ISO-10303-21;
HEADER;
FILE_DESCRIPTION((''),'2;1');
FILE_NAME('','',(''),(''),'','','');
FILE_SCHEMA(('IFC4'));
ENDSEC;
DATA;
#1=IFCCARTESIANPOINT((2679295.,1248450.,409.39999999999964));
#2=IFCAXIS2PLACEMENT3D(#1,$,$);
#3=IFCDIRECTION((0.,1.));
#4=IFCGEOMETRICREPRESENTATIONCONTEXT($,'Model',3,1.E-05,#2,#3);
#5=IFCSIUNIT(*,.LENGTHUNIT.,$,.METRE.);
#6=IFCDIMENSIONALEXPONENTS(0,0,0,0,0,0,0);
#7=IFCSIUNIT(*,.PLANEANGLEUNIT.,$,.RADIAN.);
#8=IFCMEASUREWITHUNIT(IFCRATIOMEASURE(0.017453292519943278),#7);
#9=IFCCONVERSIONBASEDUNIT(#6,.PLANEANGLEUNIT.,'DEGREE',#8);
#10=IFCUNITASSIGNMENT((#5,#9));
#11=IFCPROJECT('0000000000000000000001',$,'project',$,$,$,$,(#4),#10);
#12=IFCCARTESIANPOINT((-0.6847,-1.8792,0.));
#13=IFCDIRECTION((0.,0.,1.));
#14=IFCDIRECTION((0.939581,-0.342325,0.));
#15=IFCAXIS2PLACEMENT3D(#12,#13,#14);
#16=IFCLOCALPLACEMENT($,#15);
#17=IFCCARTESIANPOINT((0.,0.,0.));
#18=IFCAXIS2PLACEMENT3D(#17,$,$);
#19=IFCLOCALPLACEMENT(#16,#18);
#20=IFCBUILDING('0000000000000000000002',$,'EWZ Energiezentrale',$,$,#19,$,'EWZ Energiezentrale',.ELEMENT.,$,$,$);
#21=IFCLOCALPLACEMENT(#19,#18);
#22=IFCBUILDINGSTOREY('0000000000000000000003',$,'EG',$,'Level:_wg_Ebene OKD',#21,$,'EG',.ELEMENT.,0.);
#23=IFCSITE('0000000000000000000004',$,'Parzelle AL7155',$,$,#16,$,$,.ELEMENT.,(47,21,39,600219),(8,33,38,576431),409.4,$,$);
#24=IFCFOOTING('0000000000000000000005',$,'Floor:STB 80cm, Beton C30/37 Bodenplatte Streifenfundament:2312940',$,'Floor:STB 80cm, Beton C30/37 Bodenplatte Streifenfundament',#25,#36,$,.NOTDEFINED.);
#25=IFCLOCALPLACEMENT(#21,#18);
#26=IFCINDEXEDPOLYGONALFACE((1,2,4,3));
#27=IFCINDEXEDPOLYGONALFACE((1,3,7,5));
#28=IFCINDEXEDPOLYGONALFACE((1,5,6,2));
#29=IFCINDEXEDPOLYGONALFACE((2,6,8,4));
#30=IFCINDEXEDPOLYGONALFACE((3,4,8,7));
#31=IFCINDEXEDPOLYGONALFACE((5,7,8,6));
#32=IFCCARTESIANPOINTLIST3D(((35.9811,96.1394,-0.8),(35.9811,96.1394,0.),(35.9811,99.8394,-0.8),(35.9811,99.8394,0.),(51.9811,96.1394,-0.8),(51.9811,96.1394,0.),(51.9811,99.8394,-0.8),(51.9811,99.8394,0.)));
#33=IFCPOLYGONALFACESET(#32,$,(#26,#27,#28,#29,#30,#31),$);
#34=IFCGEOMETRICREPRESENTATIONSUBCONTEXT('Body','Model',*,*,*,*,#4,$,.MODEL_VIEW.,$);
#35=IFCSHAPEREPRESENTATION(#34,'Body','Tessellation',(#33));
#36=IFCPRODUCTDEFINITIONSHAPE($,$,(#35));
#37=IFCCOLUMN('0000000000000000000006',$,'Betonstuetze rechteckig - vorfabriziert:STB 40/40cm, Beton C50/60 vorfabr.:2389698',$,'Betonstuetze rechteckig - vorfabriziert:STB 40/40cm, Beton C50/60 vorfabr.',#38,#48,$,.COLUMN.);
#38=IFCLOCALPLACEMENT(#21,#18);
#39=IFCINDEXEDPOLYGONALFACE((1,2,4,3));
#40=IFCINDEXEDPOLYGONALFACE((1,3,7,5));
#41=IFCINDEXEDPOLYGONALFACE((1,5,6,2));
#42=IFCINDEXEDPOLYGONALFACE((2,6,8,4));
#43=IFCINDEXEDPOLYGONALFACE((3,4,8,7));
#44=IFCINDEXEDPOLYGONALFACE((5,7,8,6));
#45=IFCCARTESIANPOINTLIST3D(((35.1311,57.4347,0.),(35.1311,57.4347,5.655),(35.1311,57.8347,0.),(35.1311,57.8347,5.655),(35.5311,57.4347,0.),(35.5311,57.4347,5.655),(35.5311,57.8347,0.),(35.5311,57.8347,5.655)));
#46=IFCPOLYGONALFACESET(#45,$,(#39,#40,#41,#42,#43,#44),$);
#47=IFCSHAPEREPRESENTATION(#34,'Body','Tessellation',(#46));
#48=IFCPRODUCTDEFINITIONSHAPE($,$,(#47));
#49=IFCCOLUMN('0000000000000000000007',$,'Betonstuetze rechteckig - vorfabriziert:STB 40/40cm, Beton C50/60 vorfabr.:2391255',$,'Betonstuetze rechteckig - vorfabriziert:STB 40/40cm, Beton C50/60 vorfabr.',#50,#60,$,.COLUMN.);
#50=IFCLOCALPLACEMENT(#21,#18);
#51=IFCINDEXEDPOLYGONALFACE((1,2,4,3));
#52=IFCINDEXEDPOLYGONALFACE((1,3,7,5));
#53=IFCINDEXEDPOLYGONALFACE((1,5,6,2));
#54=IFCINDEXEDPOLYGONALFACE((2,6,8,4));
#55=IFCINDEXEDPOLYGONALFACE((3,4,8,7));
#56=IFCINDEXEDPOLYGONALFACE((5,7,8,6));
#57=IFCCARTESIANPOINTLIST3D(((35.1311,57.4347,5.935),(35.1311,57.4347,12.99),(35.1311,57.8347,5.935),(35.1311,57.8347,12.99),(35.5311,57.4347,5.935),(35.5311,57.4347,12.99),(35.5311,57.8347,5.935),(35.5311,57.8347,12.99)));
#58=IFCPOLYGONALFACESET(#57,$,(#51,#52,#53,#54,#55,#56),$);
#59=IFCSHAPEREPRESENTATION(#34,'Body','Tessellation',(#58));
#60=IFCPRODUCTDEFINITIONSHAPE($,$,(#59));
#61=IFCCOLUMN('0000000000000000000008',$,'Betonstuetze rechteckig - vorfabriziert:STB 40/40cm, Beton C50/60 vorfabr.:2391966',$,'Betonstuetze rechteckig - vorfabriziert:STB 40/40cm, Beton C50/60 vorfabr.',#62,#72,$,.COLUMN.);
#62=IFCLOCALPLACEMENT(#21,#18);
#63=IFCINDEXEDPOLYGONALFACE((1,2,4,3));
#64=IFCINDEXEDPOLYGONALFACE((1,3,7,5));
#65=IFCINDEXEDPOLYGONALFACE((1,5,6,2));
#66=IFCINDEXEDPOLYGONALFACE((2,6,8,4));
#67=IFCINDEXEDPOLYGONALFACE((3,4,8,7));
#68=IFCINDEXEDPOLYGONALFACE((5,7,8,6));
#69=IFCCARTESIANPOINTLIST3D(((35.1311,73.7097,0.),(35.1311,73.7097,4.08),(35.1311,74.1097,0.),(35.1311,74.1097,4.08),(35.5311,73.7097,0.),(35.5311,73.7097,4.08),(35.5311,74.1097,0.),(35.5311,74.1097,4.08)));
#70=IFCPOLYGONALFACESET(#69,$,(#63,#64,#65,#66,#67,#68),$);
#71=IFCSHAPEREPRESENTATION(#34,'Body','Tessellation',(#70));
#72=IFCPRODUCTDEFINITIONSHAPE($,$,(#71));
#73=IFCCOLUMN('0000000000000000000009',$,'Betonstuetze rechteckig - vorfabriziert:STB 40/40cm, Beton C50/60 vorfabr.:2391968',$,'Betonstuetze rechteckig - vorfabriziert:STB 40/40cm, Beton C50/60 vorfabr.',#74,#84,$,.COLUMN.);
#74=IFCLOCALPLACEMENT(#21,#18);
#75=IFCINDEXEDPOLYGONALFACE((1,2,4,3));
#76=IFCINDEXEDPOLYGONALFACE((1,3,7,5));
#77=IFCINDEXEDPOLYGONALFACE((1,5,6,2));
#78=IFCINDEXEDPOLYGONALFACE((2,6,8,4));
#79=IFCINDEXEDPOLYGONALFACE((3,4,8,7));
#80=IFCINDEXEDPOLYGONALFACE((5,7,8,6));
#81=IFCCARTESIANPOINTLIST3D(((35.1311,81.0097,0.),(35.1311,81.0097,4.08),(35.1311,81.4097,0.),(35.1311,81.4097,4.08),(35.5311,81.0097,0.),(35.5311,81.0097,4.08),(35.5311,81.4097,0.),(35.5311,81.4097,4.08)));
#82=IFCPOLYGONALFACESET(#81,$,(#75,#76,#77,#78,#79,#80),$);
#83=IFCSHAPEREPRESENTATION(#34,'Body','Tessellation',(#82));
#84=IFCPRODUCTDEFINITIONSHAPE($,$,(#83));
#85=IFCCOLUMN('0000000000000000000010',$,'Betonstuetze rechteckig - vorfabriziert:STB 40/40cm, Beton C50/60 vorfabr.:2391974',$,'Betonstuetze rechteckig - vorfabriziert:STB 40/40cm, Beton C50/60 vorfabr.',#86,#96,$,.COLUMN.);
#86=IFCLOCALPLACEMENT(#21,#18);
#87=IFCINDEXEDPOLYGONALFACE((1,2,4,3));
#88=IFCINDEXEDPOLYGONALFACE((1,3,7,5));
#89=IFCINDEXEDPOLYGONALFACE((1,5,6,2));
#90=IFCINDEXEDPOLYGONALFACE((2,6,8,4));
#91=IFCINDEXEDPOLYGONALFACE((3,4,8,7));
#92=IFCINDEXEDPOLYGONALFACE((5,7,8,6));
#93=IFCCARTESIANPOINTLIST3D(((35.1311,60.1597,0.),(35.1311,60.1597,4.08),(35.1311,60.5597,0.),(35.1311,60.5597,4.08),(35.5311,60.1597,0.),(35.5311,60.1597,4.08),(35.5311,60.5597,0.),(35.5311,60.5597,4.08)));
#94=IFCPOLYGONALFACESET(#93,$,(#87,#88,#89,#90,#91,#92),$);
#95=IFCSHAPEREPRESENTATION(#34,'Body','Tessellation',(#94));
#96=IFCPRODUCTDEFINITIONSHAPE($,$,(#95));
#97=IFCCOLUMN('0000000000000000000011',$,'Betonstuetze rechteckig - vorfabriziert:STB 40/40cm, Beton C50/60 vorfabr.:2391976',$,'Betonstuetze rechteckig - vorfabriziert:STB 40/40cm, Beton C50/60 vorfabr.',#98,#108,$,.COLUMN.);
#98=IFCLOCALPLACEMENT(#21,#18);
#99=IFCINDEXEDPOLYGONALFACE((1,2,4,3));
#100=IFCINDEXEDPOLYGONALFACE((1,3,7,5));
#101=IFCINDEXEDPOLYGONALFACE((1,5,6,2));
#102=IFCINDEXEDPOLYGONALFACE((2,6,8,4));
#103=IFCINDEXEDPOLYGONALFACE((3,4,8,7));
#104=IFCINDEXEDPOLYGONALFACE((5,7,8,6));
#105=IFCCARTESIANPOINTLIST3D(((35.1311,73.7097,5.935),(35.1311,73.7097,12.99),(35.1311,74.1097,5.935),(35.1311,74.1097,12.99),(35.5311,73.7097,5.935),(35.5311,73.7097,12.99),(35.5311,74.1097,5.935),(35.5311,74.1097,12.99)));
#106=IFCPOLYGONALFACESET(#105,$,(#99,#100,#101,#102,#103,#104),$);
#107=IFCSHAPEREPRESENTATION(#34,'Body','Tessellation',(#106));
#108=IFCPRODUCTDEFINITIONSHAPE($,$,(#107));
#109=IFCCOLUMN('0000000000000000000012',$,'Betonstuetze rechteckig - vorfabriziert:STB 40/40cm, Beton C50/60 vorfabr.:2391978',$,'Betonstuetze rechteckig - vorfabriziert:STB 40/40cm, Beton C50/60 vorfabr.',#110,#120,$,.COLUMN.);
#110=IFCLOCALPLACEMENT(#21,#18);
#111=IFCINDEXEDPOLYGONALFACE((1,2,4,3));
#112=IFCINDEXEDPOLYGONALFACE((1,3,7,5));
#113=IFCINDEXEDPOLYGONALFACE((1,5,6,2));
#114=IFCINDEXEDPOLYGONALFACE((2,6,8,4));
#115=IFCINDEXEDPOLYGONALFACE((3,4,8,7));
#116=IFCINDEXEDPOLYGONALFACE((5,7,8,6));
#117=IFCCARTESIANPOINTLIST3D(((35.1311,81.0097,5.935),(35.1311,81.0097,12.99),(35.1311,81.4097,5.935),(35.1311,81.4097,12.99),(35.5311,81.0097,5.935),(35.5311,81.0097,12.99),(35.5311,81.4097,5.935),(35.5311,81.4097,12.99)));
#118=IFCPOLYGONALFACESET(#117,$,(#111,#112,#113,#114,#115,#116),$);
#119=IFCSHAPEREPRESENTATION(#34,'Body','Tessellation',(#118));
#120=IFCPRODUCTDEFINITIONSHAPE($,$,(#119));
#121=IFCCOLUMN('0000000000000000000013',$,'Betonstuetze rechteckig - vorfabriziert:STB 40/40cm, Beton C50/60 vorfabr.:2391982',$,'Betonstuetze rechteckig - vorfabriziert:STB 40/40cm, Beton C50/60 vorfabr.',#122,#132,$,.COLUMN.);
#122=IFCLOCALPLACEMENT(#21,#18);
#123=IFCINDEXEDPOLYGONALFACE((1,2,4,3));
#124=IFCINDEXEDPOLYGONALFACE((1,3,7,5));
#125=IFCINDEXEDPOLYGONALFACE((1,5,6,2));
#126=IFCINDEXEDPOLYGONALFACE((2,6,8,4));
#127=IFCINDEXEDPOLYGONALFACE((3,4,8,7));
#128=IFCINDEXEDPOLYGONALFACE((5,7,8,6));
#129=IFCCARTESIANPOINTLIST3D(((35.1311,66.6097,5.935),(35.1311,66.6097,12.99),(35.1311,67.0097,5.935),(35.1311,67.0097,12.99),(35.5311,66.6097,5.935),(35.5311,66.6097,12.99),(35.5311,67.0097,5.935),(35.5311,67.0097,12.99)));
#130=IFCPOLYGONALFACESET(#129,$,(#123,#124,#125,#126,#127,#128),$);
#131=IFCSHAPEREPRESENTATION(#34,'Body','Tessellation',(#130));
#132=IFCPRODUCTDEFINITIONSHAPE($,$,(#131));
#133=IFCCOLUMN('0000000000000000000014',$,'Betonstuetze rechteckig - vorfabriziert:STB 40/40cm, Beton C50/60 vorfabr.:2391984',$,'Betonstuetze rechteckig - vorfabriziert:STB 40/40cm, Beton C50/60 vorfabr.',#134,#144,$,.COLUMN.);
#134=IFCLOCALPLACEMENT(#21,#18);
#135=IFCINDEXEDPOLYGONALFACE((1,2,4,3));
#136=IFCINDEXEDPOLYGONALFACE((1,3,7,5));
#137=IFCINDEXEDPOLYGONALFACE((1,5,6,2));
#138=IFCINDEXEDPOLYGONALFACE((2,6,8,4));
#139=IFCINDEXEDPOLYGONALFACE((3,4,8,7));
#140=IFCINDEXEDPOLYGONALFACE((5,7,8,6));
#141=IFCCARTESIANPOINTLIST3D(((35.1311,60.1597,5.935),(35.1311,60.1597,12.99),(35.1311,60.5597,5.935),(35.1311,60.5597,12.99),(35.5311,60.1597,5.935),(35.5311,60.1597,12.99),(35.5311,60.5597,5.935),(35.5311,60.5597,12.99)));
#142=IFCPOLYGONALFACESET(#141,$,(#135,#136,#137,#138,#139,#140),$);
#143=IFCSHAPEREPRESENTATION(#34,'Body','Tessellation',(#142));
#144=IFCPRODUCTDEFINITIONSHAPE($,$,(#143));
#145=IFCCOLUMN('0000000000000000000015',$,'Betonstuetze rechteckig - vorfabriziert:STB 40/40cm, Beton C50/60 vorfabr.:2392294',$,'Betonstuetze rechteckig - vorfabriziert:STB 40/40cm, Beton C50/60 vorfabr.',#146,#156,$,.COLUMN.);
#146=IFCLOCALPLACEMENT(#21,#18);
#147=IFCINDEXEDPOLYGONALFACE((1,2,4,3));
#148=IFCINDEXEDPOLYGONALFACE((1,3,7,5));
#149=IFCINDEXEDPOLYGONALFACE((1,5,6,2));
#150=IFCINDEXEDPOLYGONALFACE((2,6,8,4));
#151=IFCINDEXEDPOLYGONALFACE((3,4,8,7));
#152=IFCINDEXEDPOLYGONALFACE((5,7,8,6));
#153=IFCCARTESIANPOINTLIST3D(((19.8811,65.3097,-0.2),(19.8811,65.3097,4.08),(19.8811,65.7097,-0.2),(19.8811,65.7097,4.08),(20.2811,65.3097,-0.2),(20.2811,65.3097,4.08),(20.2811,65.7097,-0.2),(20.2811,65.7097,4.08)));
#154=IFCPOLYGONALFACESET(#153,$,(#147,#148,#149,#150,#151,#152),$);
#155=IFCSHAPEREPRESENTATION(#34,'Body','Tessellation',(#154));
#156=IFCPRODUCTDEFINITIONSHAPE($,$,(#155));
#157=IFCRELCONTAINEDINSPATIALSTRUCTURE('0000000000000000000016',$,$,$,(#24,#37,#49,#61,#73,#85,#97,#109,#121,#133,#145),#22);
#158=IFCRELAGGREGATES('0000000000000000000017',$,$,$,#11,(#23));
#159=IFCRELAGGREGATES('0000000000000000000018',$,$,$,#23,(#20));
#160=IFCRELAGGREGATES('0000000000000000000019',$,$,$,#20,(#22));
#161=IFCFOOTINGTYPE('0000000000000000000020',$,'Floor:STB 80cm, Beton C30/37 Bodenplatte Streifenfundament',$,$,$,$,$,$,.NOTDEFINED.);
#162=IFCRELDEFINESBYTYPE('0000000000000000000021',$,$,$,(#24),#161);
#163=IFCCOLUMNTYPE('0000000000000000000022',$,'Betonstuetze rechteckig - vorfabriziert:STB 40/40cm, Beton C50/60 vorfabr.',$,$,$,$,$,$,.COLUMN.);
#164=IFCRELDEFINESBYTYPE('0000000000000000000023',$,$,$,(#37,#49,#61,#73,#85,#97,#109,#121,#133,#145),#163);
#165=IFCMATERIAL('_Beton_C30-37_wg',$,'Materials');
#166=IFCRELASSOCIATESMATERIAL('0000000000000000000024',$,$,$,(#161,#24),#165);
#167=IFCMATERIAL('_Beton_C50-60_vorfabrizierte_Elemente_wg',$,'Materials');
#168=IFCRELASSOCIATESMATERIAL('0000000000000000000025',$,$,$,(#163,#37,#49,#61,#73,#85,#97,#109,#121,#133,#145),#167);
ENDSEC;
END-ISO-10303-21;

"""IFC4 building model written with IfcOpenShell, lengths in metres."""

from ifc_helpers import new_model, entity, si_unit, converted_unit, direction, frame, origin, place, context, subcontext, project, spatial, indexed_curve, outline, extrude, source, transform, mapped, material, type_object, type_shapes, element, save


model = new_model("IFC4")

# Units and contexts
model_context = context("Model", 3, precision=1e-05, world=frame((2679295.0, 1248450.0, 409.39999999999964)), true_north=direction((0.0, 1.0)))
body_context = subcontext(model_context, "Body", "Model", "MODEL_VIEW")
ifc_project = project(units=[si_unit("LENGTHUNIT", "METRE"), converted_unit("PLANEANGLEUNIT", "DEGREE", entity("IfcRatioMeasure", 0.017453292519943278), si_unit("PLANEANGLEUNIT", "RADIAN"), dimensions=[0, 0, 0, 0, 0, 0, 0])], contexts=[model_context])

# Site, building, storey
site_placement = place(None, frame((-0.6847, -1.8792, 0.0), z_axis=(0.0, 0.0, 1.0), x_axis=(0.939581, -0.342325, 0.0)))
site = spatial("IfcSite", under=ifc_project, at=site_placement, Name="Parzelle AL7155", CompositionType="ELEMENT", RefLatitude=(47, 21, 39, 600219), RefLongitude=(8, 33, 38, 576431), RefElevation=409.4)
building_placement = place(site_placement, origin())
building = spatial("IfcBuilding", under=site, at=building_placement, Name="EWZ Energiezentrale", LongName="EWZ Energiezentrale", CompositionType="ELEMENT")
storey_placement = place(building_placement, origin())
storey = spatial("IfcBuildingStorey", under=building, at=storey_placement, Name="EG", ObjectType="Level:_wg_Ebene OKD", LongName="EG", CompositionType="ELEMENT", Elevation=0.0)

# Footing
ifc_material_1 = material(Name="_Beton_C30-37_wg", Category="Materials")
footing_type = type_object("IfcFootingType", Name="Floor:STB 80cm, Beton C30/37 Bodenplatte Streifenfundament", PredefinedType="NOTDEFINED", material=ifc_material_1)
footing_placement = place(storey_placement, origin())
element("IfcFooting", 1, at=footing_placement, inside=storey, type_object=footing_type, material=ifc_material_1, Name="Floor:STB 80cm, Beton C30/37 Bodenplatte Streifenfundament:2312940", ObjectType="Floor:STB 80cm, Beton C30/37 Bodenplatte Streifenfundament", PredefinedType="NOTDEFINED", context=body_context, shape_type="SweptSolid", body=[
    extrude(outline(indexed_curve([(-1.85, -8.0), (1.85, -8.0), (1.85, 8.0), (-1.85, 8.0), (-1.85, -8.0)], self_intersect=False)), frame((43.9811, 97.9894, 0.0), z_axis=(0.0, 0.0, -1.0), x_axis=(0.0, 1.0, 0.0)), (0.0, 0.0, 1.0), 0.8),
])

# Columns
ifc_material_2 = material(Name="_Beton_C50-60_vorfabrizierte_Elemente_wg", Category="Materials")
column_type = type_object("IfcColumnType", Name="Betonstuetze rechteckig - vorfabriziert:STB 40/40cm, Beton C50/60 vorfabr.", PredefinedType="COLUMN", material=ifc_material_2)
shared_shape_1 = source(origin(), body_context, "Body", "SweptSolid", [
    extrude(outline(indexed_curve([(-0.2, -0.2), (0.2, -0.2), (0.2, 0.2), (-0.2, 0.2), (-0.2, -0.2)], self_intersect=False)), frame((35.3311, 57.6347, 0.0), z_axis=(0.0, 0.0, 1.0), x_axis=(0.0, -1.0, 0.0)), (0.0, 0.0, 1.0), 5.655),
])
type_shapes(column_type, [shared_shape_1])
column_1_placement = place(storey_placement, origin())
element("IfcColumn", 2, at=column_1_placement, inside=storey, type_object=column_type, material=ifc_material_2, Name="Betonstuetze rechteckig - vorfabriziert:STB 40/40cm, Beton C50/60 vorfabr.:2389698", ObjectType="Betonstuetze rechteckig - vorfabriziert:STB 40/40cm, Beton C50/60 vorfabr.", PredefinedType="COLUMN", context=body_context, shape_type="MappedRepresentation", body=[
    mapped(shared_shape_1, transform((0.0, 0.0, 0.0), scale=1.0)),
])
shared_shape_2 = source(origin(), body_context, "Body", "SweptSolid", [
    extrude(outline(indexed_curve([(-0.2, -0.2), (0.2, -0.2), (0.2, 0.2), (-0.2, 0.2), (-0.2, -0.2)], self_intersect=False)), frame((35.3311, 57.6347, 5.935), z_axis=(0.0, 0.0, 1.0), x_axis=(0.0, -1.0, 0.0)), (0.0, 0.0, 1.0), 7.055),
])
column_2_placement = place(storey_placement, frame((0.0, 0.0, 0.0), z_axis=(0.0, 0.0, 1.0), x_axis=(1.0, 0.0, 0.0)))
element("IfcColumn", 3, at=column_2_placement, inside=storey, type_object=column_type, material=ifc_material_2, Name="Betonstuetze rechteckig - vorfabriziert:STB 40/40cm, Beton C50/60 vorfabr.:2391255", ObjectType="Betonstuetze rechteckig - vorfabriziert:STB 40/40cm, Beton C50/60 vorfabr.", PredefinedType="COLUMN", context=body_context, shape_type="MappedRepresentation", body=[
    mapped(shared_shape_2, transform((0.0, 0.0, 0.0), scale=1.0)),
])
shared_shape_3 = source(origin(), body_context, "Body", "SweptSolid", [
    extrude(outline(indexed_curve([(-0.2, -0.2), (0.2, -0.2), (0.2, 0.2), (-0.2, 0.2), (-0.2, -0.2)], self_intersect=False)), frame((35.3311, 73.9097, 0.0), z_axis=(0.0, 0.0, 1.0), x_axis=(0.0, -1.0, 0.0)), (0.0, 0.0, 1.0), 4.08),
])
column_3_placement = place(storey_placement, origin())
element("IfcColumn", 4, at=column_3_placement, inside=storey, type_object=column_type, material=ifc_material_2, Name="Betonstuetze rechteckig - vorfabriziert:STB 40/40cm, Beton C50/60 vorfabr.:2391966", ObjectType="Betonstuetze rechteckig - vorfabriziert:STB 40/40cm, Beton C50/60 vorfabr.", PredefinedType="COLUMN", context=body_context, shape_type="MappedRepresentation", body=[
    mapped(shared_shape_3, transform((0.0, 0.0, 0.0), scale=1.0)),
])
shared_shape_4 = source(origin(), body_context, "Body", "SweptSolid", [
    extrude(outline(indexed_curve([(-0.2, -0.2), (0.2, -0.2), (0.2, 0.2), (-0.2, 0.2), (-0.2, -0.2)], self_intersect=False)), frame((35.3311, 81.2097, 0.0), z_axis=(0.0, 0.0, 1.0), x_axis=(0.0, -1.0, 0.0)), (0.0, 0.0, 1.0), 4.08),
])
column_4_placement = place(storey_placement, origin())
element("IfcColumn", 5, at=column_4_placement, inside=storey, type_object=column_type, material=ifc_material_2, Name="Betonstuetze rechteckig - vorfabriziert:STB 40/40cm, Beton C50/60 vorfabr.:2391968", ObjectType="Betonstuetze rechteckig - vorfabriziert:STB 40/40cm, Beton C50/60 vorfabr.", PredefinedType="COLUMN", context=body_context, shape_type="MappedRepresentation", body=[
    mapped(shared_shape_4, transform((0.0, 0.0, 0.0), scale=1.0)),
])
shared_shape_5 = source(origin(), body_context, "Body", "SweptSolid", [
    extrude(outline(indexed_curve([(-0.2, -0.2), (0.2, -0.2), (0.2, 0.2), (-0.2, 0.2), (-0.2, -0.2)], self_intersect=False)), frame((35.3311, 60.3597, 0.0), z_axis=(0.0, 0.0, 1.0), x_axis=(-1.0, 0.0, 0.0)), (0.0, 0.0, 1.0), 4.08),
])
column_5_placement = place(storey_placement, origin())
element("IfcColumn", 6, at=column_5_placement, inside=storey, type_object=column_type, material=ifc_material_2, Name="Betonstuetze rechteckig - vorfabriziert:STB 40/40cm, Beton C50/60 vorfabr.:2391974", ObjectType="Betonstuetze rechteckig - vorfabriziert:STB 40/40cm, Beton C50/60 vorfabr.", PredefinedType="COLUMN", context=body_context, shape_type="MappedRepresentation", body=[
    mapped(shared_shape_5, transform((0.0, 0.0, 0.0), scale=1.0)),
])
shared_shape_6 = source(origin(), body_context, "Body", "SweptSolid", [
    extrude(outline(indexed_curve([(-0.2, -0.2), (0.2, -0.2), (0.2, 0.2), (-0.2, 0.2), (-0.2, -0.2)], self_intersect=False)), frame((35.3311, 73.9097, 5.935), z_axis=(0.0, 0.0, 1.0), x_axis=(0.0, -1.0, 0.0)), (0.0, 0.0, 1.0), 7.055),
])
column_6_placement = place(storey_placement, frame((0.0, 0.0, 0.0), z_axis=(0.0, 0.0, 1.0), x_axis=(1.0, 0.0, 0.0)))
element("IfcColumn", 7, at=column_6_placement, inside=storey, type_object=column_type, material=ifc_material_2, Name="Betonstuetze rechteckig - vorfabriziert:STB 40/40cm, Beton C50/60 vorfabr.:2391976", ObjectType="Betonstuetze rechteckig - vorfabriziert:STB 40/40cm, Beton C50/60 vorfabr.", PredefinedType="COLUMN", context=body_context, shape_type="MappedRepresentation", body=[
    mapped(shared_shape_6, transform((0.0, 0.0, 0.0), scale=1.0)),
])
shared_shape_7 = source(origin(), body_context, "Body", "SweptSolid", [
    extrude(outline(indexed_curve([(-0.2, -0.2), (0.2, -0.2), (0.2, 0.2), (-0.2, 0.2), (-0.2, -0.2)], self_intersect=False)), frame((35.3311, 81.2097, 5.935), z_axis=(0.0, 0.0, 1.0), x_axis=(0.0, -1.0, 0.0)), (0.0, 0.0, 1.0), 7.055),
])
column_7_placement = place(storey_placement, frame((0.0, 0.0, 0.0), z_axis=(0.0, 0.0, 1.0), x_axis=(1.0, 0.0, 0.0)))
element("IfcColumn", 8, at=column_7_placement, inside=storey, type_object=column_type, material=ifc_material_2, Name="Betonstuetze rechteckig - vorfabriziert:STB 40/40cm, Beton C50/60 vorfabr.:2391978", ObjectType="Betonstuetze rechteckig - vorfabriziert:STB 40/40cm, Beton C50/60 vorfabr.", PredefinedType="COLUMN", context=body_context, shape_type="MappedRepresentation", body=[
    mapped(shared_shape_7, transform((0.0, 0.0, 0.0), scale=1.0)),
])
shared_shape_8 = source(origin(), body_context, "Body", "SweptSolid", [
    extrude(outline(indexed_curve([(-0.2, -0.2), (0.2, -0.2), (0.2, 0.2), (-0.2, 0.2), (-0.2, -0.2)], self_intersect=False)), frame((35.3311, 66.8097, 5.935), z_axis=(0.0, 0.0, 1.0), x_axis=(0.0, -1.0, 0.0)), (0.0, 0.0, 1.0), 7.055),
])
column_8_placement = place(storey_placement, frame((0.0, 0.0, 0.0), z_axis=(0.0, 0.0, 1.0), x_axis=(1.0, 0.0, 0.0)))
element("IfcColumn", 9, at=column_8_placement, inside=storey, type_object=column_type, material=ifc_material_2, Name="Betonstuetze rechteckig - vorfabriziert:STB 40/40cm, Beton C50/60 vorfabr.:2391982", ObjectType="Betonstuetze rechteckig - vorfabriziert:STB 40/40cm, Beton C50/60 vorfabr.", PredefinedType="COLUMN", context=body_context, shape_type="MappedRepresentation", body=[
    mapped(shared_shape_8, transform((0.0, 0.0, 0.0), scale=1.0)),
])
shared_shape_9 = source(origin(), body_context, "Body", "SweptSolid", [
    extrude(outline(indexed_curve([(-0.2, -0.2), (0.2, -0.2), (0.2, 0.2), (-0.2, 0.2), (-0.2, -0.2)], self_intersect=False)), frame((35.3311, 60.3597, 5.935), z_axis=(0.0, 0.0, 1.0), x_axis=(-1.0, 0.0, 0.0)), (0.0, 0.0, 1.0), 7.055),
])
column_9_placement = place(storey_placement, frame((0.0, 0.0, 0.0), z_axis=(0.0, 0.0, 1.0), x_axis=(1.0, 0.0, 0.0)))
element("IfcColumn", 10, at=column_9_placement, inside=storey, type_object=column_type, material=ifc_material_2, Name="Betonstuetze rechteckig - vorfabriziert:STB 40/40cm, Beton C50/60 vorfabr.:2391984", ObjectType="Betonstuetze rechteckig - vorfabriziert:STB 40/40cm, Beton C50/60 vorfabr.", PredefinedType="COLUMN", context=body_context, shape_type="MappedRepresentation", body=[
    mapped(shared_shape_9, transform((0.0, 0.0, 0.0), scale=1.0)),
])
shared_shape_10 = source(origin(), body_context, "Body", "SweptSolid", [
    extrude(outline(indexed_curve([(-0.2, -0.2), (0.2, -0.2), (0.2, 0.2), (-0.2, 0.2), (-0.2, -0.2)], self_intersect=False)), frame((20.0811, 65.5097, -0.2), z_axis=(0.0, 0.0, 1.0), x_axis=(-1.0, 0.0, 0.0)), (0.0, 0.0, 1.0), 4.28),
])
column_10_placement = place(storey_placement, origin())
element("IfcColumn", 11, at=column_10_placement, inside=storey, type_object=column_type, material=ifc_material_2, Name="Betonstuetze rechteckig - vorfabriziert:STB 40/40cm, Beton C50/60 vorfabr.:2392294", ObjectType="Betonstuetze rechteckig - vorfabriziert:STB 40/40cm, Beton C50/60 vorfabr.", PredefinedType="COLUMN", context=body_context, shape_type="MappedRepresentation", body=[
    mapped(shared_shape_10, transform((0.0, 0.0, 0.0), scale=1.0)),
])

save(model, "model.ifc")
